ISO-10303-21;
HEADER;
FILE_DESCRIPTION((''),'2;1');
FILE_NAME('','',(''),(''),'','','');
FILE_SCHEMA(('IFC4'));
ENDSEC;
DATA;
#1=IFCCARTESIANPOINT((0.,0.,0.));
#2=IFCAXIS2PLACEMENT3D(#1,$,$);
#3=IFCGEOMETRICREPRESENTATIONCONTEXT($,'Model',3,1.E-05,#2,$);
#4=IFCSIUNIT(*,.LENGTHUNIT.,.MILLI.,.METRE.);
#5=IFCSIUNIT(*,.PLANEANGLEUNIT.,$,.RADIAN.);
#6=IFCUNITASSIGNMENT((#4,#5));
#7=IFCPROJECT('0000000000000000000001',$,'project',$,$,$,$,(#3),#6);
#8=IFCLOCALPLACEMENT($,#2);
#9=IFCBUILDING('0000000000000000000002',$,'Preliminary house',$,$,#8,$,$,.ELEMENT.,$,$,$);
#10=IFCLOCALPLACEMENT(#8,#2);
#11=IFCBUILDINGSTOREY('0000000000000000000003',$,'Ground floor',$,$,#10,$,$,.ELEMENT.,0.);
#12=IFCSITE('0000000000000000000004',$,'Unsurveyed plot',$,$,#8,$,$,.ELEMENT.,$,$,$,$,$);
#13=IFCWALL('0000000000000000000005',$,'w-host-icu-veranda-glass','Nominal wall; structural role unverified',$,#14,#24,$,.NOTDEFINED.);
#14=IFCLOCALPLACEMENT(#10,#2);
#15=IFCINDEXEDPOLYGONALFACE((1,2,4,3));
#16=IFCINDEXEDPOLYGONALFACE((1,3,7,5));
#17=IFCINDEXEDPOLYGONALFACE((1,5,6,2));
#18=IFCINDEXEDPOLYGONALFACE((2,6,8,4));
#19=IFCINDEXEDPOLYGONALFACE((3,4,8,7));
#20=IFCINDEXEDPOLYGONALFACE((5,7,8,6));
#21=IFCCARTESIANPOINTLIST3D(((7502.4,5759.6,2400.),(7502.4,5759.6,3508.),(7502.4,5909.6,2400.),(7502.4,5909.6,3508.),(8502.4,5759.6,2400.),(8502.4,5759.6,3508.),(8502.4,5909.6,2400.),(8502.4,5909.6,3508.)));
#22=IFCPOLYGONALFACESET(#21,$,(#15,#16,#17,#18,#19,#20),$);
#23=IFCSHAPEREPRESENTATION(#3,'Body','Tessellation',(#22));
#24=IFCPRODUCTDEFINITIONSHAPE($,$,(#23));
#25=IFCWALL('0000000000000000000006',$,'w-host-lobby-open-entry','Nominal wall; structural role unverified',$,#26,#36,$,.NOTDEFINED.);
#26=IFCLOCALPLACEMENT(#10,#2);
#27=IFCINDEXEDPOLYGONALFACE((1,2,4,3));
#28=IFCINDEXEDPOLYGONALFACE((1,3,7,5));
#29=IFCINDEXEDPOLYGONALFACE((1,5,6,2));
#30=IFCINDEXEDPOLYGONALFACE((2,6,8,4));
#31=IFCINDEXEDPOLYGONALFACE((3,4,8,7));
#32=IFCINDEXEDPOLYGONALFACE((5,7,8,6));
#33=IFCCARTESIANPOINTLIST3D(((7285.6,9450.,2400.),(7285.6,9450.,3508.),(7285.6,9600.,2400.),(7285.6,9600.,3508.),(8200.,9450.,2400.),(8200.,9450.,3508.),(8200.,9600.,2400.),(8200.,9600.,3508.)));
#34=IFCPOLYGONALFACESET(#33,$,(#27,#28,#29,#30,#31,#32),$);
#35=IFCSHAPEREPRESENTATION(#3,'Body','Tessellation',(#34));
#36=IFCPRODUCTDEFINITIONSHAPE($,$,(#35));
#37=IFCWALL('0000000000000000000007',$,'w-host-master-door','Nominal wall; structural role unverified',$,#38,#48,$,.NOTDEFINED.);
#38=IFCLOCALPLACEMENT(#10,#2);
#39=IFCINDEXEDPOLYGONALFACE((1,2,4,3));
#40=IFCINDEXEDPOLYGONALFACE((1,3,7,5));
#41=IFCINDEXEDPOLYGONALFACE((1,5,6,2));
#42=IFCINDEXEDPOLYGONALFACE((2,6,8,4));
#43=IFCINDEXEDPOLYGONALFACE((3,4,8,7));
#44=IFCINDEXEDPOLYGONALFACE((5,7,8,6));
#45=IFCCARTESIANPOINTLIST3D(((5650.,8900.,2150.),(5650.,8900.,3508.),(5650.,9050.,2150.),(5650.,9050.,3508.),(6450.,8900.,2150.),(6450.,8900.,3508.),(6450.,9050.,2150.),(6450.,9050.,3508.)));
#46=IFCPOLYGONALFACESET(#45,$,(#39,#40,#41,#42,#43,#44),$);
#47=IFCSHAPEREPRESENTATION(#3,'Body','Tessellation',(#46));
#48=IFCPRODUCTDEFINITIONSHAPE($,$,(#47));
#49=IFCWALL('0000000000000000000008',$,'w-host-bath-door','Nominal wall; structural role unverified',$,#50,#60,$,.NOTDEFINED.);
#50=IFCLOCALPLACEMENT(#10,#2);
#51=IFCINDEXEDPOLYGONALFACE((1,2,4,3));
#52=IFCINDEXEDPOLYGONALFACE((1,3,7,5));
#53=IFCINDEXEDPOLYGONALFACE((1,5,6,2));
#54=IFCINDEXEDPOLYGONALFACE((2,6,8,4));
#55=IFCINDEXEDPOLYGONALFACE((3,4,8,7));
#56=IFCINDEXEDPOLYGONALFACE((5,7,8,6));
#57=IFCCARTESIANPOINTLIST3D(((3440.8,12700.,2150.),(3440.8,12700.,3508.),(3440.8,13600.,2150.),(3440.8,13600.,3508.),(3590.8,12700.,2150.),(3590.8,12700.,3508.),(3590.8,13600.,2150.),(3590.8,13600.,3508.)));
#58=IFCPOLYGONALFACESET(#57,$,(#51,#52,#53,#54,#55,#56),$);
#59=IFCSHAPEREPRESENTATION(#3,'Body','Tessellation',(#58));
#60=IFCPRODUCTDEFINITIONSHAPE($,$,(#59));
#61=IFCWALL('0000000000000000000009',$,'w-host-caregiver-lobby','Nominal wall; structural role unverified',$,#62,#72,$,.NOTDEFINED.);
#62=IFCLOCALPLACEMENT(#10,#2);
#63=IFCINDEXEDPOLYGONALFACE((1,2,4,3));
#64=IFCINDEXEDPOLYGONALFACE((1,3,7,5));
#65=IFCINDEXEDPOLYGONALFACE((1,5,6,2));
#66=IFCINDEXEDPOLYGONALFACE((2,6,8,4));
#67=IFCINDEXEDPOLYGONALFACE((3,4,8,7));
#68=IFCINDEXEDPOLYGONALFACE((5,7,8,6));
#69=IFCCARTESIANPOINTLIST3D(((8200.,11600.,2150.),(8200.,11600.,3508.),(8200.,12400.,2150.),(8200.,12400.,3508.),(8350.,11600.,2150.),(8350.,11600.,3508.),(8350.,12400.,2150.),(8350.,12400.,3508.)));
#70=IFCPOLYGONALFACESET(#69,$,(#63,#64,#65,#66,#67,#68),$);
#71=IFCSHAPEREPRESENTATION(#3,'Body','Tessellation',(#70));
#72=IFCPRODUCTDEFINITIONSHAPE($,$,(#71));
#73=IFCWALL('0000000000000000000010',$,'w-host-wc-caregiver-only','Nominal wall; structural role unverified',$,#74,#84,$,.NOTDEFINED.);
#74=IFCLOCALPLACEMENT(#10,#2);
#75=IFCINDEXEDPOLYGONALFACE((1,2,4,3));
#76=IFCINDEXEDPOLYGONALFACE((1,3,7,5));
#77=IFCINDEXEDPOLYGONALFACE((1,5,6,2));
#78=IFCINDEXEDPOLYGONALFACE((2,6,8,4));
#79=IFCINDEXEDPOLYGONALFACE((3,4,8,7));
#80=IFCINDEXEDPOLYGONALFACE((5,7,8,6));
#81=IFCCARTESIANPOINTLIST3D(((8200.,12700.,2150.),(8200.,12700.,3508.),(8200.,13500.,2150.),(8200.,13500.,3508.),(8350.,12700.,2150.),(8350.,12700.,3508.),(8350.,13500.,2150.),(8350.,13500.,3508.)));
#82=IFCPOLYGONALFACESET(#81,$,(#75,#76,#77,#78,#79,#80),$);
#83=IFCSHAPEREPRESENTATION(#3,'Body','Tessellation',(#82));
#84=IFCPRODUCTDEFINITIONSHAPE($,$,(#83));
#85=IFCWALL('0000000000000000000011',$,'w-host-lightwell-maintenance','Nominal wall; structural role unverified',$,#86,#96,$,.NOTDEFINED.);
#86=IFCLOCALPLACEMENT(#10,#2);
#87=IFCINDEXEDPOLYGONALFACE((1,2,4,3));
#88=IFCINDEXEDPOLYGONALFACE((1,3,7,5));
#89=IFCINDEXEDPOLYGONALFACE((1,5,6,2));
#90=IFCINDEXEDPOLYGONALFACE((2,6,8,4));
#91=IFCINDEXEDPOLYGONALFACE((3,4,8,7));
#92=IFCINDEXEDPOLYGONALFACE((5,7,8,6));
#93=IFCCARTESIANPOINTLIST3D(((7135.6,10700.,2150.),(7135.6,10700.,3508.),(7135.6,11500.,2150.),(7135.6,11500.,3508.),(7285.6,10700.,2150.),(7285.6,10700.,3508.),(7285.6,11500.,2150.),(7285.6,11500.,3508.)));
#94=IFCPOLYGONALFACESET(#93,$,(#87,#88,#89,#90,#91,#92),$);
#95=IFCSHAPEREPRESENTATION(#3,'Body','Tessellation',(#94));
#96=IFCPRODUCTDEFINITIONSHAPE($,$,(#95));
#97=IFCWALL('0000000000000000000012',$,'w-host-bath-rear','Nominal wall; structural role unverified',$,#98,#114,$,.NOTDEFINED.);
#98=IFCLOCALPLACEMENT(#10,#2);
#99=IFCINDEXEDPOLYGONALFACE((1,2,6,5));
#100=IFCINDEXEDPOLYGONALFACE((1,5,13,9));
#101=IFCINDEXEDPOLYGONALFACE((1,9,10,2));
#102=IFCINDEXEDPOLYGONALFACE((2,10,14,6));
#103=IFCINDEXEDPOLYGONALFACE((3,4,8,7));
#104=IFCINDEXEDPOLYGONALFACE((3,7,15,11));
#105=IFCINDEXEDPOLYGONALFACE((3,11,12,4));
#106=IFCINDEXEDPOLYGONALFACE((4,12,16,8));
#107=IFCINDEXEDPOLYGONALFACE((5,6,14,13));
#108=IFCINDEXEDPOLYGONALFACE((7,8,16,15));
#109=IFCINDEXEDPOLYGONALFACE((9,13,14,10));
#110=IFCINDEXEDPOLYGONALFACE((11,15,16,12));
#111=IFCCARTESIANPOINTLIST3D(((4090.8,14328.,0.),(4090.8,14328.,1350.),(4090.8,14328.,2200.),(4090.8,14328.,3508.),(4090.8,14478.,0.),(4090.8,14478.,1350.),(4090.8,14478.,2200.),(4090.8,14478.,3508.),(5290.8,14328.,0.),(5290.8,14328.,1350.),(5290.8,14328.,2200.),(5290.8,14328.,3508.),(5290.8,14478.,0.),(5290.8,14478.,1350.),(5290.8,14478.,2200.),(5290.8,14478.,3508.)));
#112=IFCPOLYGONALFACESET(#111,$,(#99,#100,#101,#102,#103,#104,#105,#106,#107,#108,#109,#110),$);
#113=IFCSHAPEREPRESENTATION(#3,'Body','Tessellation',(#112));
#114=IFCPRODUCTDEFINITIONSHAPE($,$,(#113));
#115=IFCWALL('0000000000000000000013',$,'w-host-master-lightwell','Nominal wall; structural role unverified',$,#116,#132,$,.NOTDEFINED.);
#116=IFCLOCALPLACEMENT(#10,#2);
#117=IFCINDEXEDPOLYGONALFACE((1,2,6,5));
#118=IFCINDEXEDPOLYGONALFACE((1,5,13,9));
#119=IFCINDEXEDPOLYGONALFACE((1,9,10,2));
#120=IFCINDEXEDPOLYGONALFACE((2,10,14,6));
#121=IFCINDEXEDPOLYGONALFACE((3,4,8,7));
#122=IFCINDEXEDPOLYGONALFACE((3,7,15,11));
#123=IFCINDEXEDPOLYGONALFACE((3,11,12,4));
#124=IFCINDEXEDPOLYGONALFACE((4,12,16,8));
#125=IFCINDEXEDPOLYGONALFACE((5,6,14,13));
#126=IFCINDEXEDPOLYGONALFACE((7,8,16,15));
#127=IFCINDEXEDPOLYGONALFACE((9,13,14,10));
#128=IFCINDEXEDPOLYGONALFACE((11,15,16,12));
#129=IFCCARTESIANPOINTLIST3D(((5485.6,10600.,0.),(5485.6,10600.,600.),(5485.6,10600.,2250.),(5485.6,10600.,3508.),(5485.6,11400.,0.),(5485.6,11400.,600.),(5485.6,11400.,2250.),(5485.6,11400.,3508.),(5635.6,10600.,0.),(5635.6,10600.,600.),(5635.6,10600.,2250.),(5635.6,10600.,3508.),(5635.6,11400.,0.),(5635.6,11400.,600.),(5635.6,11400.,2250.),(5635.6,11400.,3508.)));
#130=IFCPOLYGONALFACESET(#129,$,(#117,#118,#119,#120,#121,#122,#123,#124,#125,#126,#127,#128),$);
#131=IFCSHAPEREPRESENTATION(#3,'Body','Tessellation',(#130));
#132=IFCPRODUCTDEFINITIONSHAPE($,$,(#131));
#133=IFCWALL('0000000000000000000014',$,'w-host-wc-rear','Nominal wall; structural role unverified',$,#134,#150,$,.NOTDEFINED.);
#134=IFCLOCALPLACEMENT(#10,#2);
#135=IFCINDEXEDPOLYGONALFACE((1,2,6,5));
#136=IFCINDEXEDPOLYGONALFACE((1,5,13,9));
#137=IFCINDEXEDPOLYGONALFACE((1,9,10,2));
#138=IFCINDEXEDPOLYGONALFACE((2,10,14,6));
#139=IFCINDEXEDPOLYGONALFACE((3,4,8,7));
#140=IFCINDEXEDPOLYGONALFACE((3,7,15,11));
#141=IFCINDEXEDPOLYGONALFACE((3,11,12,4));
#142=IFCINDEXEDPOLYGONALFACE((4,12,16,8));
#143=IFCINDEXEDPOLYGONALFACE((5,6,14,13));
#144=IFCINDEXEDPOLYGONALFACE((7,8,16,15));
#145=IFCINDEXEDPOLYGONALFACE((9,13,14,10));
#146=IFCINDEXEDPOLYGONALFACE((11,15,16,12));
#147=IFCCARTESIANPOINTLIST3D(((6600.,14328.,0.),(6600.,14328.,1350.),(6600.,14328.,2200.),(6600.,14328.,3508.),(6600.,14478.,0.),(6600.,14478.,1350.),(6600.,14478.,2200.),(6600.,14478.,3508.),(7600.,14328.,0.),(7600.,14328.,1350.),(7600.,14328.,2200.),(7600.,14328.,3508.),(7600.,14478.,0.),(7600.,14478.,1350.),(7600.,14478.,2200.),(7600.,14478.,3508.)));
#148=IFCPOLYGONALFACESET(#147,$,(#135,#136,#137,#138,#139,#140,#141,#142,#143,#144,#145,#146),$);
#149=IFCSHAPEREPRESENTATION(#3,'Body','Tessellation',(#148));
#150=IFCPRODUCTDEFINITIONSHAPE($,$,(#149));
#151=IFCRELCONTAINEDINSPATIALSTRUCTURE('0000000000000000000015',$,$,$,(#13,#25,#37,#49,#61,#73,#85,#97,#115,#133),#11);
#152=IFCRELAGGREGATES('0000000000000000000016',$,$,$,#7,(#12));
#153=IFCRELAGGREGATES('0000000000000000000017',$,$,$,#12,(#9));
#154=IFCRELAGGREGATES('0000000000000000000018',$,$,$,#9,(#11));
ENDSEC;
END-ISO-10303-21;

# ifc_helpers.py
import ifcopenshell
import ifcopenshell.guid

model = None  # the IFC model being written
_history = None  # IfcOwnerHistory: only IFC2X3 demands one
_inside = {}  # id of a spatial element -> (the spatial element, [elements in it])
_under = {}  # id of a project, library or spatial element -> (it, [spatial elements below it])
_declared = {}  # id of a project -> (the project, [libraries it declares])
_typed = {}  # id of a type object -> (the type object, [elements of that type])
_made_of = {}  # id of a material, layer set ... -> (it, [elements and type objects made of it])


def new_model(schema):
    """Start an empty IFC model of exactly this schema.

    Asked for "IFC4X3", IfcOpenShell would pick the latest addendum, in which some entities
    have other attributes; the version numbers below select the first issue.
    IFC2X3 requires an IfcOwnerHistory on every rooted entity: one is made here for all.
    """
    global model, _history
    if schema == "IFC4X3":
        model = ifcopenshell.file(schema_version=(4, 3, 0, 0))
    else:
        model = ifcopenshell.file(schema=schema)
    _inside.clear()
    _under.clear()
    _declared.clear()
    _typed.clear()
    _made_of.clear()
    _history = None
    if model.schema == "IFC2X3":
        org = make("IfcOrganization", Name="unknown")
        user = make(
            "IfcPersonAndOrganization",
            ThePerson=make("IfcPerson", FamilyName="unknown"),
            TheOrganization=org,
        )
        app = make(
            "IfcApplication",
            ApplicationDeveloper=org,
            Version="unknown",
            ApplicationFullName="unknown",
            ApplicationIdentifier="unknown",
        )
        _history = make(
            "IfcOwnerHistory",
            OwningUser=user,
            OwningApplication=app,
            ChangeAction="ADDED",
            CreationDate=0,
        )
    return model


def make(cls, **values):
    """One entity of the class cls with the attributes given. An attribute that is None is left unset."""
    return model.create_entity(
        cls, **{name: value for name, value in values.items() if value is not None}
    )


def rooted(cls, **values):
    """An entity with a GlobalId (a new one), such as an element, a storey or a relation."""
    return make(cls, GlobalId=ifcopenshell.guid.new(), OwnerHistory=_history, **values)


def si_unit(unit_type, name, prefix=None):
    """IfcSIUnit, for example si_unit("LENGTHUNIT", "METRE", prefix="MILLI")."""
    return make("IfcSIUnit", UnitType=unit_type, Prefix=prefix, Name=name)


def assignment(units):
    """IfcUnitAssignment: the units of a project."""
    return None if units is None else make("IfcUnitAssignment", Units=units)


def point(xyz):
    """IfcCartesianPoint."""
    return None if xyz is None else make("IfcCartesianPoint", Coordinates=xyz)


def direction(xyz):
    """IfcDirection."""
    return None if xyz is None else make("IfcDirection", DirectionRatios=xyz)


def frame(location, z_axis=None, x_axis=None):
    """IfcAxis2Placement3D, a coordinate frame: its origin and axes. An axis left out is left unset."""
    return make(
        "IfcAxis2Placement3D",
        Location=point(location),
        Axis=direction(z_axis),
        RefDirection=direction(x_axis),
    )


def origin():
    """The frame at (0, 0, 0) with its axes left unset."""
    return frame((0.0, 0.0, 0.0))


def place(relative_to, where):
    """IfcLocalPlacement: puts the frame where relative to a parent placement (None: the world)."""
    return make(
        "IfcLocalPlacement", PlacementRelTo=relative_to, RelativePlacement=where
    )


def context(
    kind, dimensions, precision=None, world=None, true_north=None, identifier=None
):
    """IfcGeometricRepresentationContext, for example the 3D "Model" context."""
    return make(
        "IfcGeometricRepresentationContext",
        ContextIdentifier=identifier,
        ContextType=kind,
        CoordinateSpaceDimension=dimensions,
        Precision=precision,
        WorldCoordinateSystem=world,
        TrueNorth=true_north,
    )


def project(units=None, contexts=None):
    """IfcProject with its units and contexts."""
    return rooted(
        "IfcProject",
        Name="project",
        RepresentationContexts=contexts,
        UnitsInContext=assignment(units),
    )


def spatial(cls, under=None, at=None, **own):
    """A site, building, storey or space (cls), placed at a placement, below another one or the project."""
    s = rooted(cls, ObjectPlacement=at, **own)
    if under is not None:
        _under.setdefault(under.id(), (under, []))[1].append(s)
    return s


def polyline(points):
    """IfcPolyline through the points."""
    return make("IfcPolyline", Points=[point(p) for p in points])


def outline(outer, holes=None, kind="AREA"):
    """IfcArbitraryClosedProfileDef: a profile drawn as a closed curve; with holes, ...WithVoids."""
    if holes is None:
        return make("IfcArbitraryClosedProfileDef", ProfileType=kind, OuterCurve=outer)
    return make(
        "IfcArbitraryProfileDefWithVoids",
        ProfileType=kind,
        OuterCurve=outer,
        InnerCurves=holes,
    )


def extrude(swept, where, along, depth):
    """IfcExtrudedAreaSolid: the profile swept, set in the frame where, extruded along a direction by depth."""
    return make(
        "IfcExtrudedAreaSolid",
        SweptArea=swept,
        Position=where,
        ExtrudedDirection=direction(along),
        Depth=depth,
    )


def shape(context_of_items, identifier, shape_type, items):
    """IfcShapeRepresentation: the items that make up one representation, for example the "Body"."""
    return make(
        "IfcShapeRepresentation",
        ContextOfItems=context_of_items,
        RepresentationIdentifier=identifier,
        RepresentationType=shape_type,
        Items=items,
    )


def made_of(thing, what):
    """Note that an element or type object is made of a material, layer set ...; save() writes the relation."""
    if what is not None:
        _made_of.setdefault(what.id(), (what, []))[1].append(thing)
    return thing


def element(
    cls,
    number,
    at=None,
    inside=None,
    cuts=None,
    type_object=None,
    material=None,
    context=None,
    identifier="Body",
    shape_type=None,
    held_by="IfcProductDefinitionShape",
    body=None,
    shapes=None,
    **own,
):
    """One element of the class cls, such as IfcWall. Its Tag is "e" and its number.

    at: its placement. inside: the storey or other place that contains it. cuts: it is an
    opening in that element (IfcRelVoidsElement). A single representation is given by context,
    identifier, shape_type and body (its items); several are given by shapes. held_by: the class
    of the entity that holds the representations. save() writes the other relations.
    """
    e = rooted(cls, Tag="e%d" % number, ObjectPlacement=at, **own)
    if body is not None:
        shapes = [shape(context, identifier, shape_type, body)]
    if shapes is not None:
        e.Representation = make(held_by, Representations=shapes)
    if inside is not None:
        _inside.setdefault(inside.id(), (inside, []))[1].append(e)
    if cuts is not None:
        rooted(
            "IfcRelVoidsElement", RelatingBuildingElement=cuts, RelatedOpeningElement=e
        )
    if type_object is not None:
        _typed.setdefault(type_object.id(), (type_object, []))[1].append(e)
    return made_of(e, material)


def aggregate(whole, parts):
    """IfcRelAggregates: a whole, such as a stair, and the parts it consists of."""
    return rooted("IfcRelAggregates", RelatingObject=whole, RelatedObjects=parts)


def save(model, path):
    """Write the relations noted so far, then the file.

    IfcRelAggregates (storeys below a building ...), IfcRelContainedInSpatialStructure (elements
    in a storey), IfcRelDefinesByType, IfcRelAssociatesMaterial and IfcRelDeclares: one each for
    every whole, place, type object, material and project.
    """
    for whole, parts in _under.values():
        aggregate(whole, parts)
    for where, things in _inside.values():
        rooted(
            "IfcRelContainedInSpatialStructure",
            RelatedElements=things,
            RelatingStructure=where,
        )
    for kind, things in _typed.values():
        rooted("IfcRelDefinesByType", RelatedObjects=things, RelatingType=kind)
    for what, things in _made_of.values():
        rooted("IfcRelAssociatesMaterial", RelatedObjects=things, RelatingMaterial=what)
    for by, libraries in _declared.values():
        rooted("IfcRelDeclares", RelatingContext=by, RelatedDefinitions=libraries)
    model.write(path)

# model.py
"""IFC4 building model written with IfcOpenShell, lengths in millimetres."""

from ifc_helpers import new_model, si_unit, frame, origin, place, context, project, spatial, polyline, outline, extrude, element, save


model = new_model("IFC4")

# Units and contexts
model_context = context("Model", 3, precision=1e-05, world=origin())
ifc_project = project(units=[si_unit("LENGTHUNIT", "METRE", prefix="MILLI"), si_unit("PLANEANGLEUNIT", "RADIAN")], contexts=[model_context])

# Site, building, storey
placement_1 = place(None, origin())
site = spatial("IfcSite", under=ifc_project, at=placement_1, Name="Unsurveyed plot", CompositionType="ELEMENT")
building = spatial("IfcBuilding", under=site, at=placement_1, Name="Preliminary house", CompositionType="ELEMENT")
placement_2 = place(placement_1, origin())
storey = spatial("IfcBuildingStorey", under=building, at=placement_2, Name="Ground floor", CompositionType="ELEMENT", Elevation=0.0)

# Walls, openings
wall_1 = element("IfcWall", 1, at=placement_2, inside=storey, Name="w-host-icu-veranda-glass", Description="Nominal wall; structural role unverified", PredefinedType="NOTDEFINED", context=model_context, shape_type="SweptSolid", body=[
    extrude(outline(polyline([(7502.4, 5759.6), (8502.4, 5759.6), (8502.4, 5909.6), (7502.4, 5909.6), (7502.4, 5759.6)])), origin(), (0.0, 0.0, 1.0), 3508.0),
])
element("IfcOpeningElement", 2, at=placement_2, cuts=wall_1, PredefinedType="OPENING", context=model_context, shape_type="SweptSolid", body=[
    extrude(outline(polyline([(7502.4, 5384.6), (8502.4, 5384.6), (8502.4, 6284.6), (7502.4, 6284.6), (7502.4, 5384.6)])), origin(), (0.0, 0.0, 1.0), 2400.0),
])
wall_2 = element("IfcWall", 3, at=placement_2, inside=storey, Name="w-host-lobby-open-entry", Description="Nominal wall; structural role unverified", PredefinedType="NOTDEFINED", context=model_context, shape_type="SweptSolid", body=[
    extrude(outline(polyline([(7285.6, 9450.0), (8200.0, 9450.0), (8200.0, 9600.0), (7285.6, 9600.0), (7285.6, 9450.0)])), origin(), (0.0, 0.0, 1.0), 3508.0),
])
element("IfcOpeningElement", 4, at=placement_2, cuts=wall_2, PredefinedType="OPENING", context=model_context, shape_type="SweptSolid", body=[
    extrude(outline(polyline([(7285.6, 9075.0), (8200.0, 9075.0), (8200.0, 9975.0), (7285.6, 9975.0), (7285.6, 9075.0)])), origin(), (0.0, 0.0, 1.0), 2400.0),
])
wall_3 = element("IfcWall", 5, at=placement_2, inside=storey, Name="w-host-master-door", Description="Nominal wall; structural role unverified", PredefinedType="NOTDEFINED", context=model_context, shape_type="SweptSolid", body=[
    extrude(outline(polyline([(5650.0, 8900.0), (6450.0, 8900.0), (6450.0, 9050.0), (5650.0, 9050.0), (5650.0, 8900.0)])), origin(), (0.0, 0.0, 1.0), 3508.0),
])
element("IfcOpeningElement", 6, at=placement_2, cuts=wall_3, PredefinedType="OPENING", context=model_context, shape_type="SweptSolid", body=[
    extrude(outline(polyline([(5650.0, 8525.0), (6450.0, 8525.0), (6450.0, 9425.0), (5650.0, 9425.0), (5650.0, 8525.0)])), origin(), (0.0, 0.0, 1.0), 2150.0),
])
wall_4 = element("IfcWall", 7, at=placement_2, inside=storey, Name="w-host-bath-door", Description="Nominal wall; structural role unverified", PredefinedType="NOTDEFINED", context=model_context, shape_type="SweptSolid", body=[
    extrude(outline(polyline([(3590.8, 12700.0), (3590.8, 13600.0), (3440.8, 13600.0), (3440.8, 12700.0), (3590.8, 12700.0)])), origin(), (0.0, 0.0, 1.0), 3508.0),
])
element("IfcOpeningElement", 8, at=placement_2, cuts=wall_4, PredefinedType="OPENING", context=model_context, shape_type="SweptSolid", body=[
    extrude(outline(polyline([(3965.8, 12700.0), (3965.8, 13600.0), (3065.8, 13600.0), (3065.8, 12700.0), (3965.8, 12700.0)])), origin(), (0.0, 0.0, 1.0), 2150.0),
])
wall_5 = element("IfcWall", 9, at=placement_2, inside=storey, Name="w-host-caregiver-lobby", Description="Nominal wall; structural role unverified", PredefinedType="NOTDEFINED", context=model_context, shape_type="SweptSolid", body=[
    extrude(outline(polyline([(8350.0, 11600.0), (8350.0, 12400.0), (8200.0, 12400.0), (8200.0, 11600.0), (8350.0, 11600.0)])), origin(), (0.0, 0.0, 1.0), 3508.0),
])
element("IfcOpeningElement", 10, at=placement_2, cuts=wall_5, PredefinedType="OPENING", context=model_context, shape_type="SweptSolid", body=[
    extrude(outline(polyline([(8725.0, 11600.0), (8725.0, 12400.0), (7825.0, 12400.0), (7825.0, 11600.0), (8725.0, 11600.0)])), origin(), (0.0, 0.0, 1.0), 2150.0),
])
wall_6 = element("IfcWall", 11, at=placement_2, inside=storey, Name="w-host-wc-caregiver-only", Description="Nominal wall; structural role unverified", PredefinedType="NOTDEFINED", context=model_context, shape_type="SweptSolid", body=[
    extrude(outline(polyline([(8350.0, 12700.0), (8350.0, 13500.0), (8200.0, 13500.0), (8200.0, 12700.0), (8350.0, 12700.0)])), origin(), (0.0, 0.0, 1.0), 3508.0),
])
element("IfcOpeningElement", 12, at=placement_2, cuts=wall_6, PredefinedType="OPENING", context=model_context, shape_type="SweptSolid", body=[
    extrude(outline(polyline([(8725.0, 12700.0), (8725.0, 13500.0), (7825.0, 13500.0), (7825.0, 12700.0), (8725.0, 12700.0)])), origin(), (0.0, 0.0, 1.0), 2150.0),
])
wall_7 = element("IfcWall", 13, at=placement_2, inside=storey, Name="w-host-lightwell-maintenance", Description="Nominal wall; structural role unverified", PredefinedType="NOTDEFINED", context=model_context, shape_type="SweptSolid", body=[
    extrude(outline(polyline([(7285.6, 10700.0), (7285.6, 11500.0), (7135.6, 11500.0), (7135.6, 10700.0), (7285.6, 10700.0)])), origin(), (0.0, 0.0, 1.0), 3508.0),
])
element("IfcOpeningElement", 14, at=placement_2, cuts=wall_7, PredefinedType="OPENING", context=model_context, shape_type="SweptSolid", body=[
    extrude(outline(polyline([(7660.6, 10700.0), (7660.6, 11500.0), (6760.6, 11500.0), (6760.6, 10700.0), (7660.6, 10700.0)])), origin(), (0.0, 0.0, 1.0), 2150.0),
])
wall_8 = element("IfcWall", 15, at=placement_2, inside=storey, Name="w-host-bath-rear", Description="Nominal wall; structural role unverified", PredefinedType="NOTDEFINED", context=model_context, shape_type="SweptSolid", body=[
    extrude(outline(polyline([(4090.8, 14328.0), (5290.8, 14328.0), (5290.8, 14478.0), (4090.8, 14478.0), (4090.8, 14328.0)])), origin(), (0.0, 0.0, 1.0), 3508.0),
])
element("IfcOpeningElement", 16, at=placement_2, cuts=wall_8, PredefinedType="OPENING", context=model_context, shape_type="SweptSolid", body=[
    extrude(outline(polyline([(4090.8, 13953.0), (5290.8, 13953.0), (5290.8, 14853.0), (4090.8, 14853.0), (4090.8, 13953.0)])), frame((0.0, 0.0, 1350.0)), (0.0, 0.0, 1.0), 850.0),
])
wall_9 = element("IfcWall", 17, at=placement_2, inside=storey, Name="w-host-master-lightwell", Description="Nominal wall; structural role unverified", PredefinedType="NOTDEFINED", context=model_context, shape_type="SweptSolid", body=[
    extrude(outline(polyline([(5635.6, 10600.0), (5635.6, 11400.0), (5485.6, 11400.0), (5485.6, 10600.0), (5635.6, 10600.0)])), origin(), (0.0, 0.0, 1.0), 3508.0),
])
element("IfcOpeningElement", 18, at=placement_2, cuts=wall_9, PredefinedType="OPENING", context=model_context, shape_type="SweptSolid", body=[
    extrude(outline(polyline([(6010.6, 10600.0), (6010.6, 11400.0), (5110.6, 11400.0), (5110.6, 10600.0), (6010.6, 10600.0)])), frame((0.0, 0.0, 600.0)), (0.0, 0.0, 1.0), 1650.0),
])
wall_10 = element("IfcWall", 19, at=placement_2, inside=storey, Name="w-host-wc-rear", Description="Nominal wall; structural role unverified", PredefinedType="NOTDEFINED", context=model_context, shape_type="SweptSolid", body=[
    extrude(outline(polyline([(6600.0, 14328.0), (7600.0, 14328.0), (7600.0, 14478.0), (6600.0, 14478.0), (6600.0, 14328.0)])), origin(), (0.0, 0.0, 1.0), 3508.0),
])
element("IfcOpeningElement", 20, at=placement_2, cuts=wall_10, PredefinedType="OPENING", context=model_context, shape_type="SweptSolid", body=[
    extrude(outline(polyline([(6600.0, 13953.0), (7600.0, 13953.0), (7600.0, 14853.0), (6600.0, 14853.0), (6600.0, 13953.0)])), frame((0.0, 0.0, 1350.0)), (0.0, 0.0, 1.0), 850.0),
])

save(model, "model.ifc")
